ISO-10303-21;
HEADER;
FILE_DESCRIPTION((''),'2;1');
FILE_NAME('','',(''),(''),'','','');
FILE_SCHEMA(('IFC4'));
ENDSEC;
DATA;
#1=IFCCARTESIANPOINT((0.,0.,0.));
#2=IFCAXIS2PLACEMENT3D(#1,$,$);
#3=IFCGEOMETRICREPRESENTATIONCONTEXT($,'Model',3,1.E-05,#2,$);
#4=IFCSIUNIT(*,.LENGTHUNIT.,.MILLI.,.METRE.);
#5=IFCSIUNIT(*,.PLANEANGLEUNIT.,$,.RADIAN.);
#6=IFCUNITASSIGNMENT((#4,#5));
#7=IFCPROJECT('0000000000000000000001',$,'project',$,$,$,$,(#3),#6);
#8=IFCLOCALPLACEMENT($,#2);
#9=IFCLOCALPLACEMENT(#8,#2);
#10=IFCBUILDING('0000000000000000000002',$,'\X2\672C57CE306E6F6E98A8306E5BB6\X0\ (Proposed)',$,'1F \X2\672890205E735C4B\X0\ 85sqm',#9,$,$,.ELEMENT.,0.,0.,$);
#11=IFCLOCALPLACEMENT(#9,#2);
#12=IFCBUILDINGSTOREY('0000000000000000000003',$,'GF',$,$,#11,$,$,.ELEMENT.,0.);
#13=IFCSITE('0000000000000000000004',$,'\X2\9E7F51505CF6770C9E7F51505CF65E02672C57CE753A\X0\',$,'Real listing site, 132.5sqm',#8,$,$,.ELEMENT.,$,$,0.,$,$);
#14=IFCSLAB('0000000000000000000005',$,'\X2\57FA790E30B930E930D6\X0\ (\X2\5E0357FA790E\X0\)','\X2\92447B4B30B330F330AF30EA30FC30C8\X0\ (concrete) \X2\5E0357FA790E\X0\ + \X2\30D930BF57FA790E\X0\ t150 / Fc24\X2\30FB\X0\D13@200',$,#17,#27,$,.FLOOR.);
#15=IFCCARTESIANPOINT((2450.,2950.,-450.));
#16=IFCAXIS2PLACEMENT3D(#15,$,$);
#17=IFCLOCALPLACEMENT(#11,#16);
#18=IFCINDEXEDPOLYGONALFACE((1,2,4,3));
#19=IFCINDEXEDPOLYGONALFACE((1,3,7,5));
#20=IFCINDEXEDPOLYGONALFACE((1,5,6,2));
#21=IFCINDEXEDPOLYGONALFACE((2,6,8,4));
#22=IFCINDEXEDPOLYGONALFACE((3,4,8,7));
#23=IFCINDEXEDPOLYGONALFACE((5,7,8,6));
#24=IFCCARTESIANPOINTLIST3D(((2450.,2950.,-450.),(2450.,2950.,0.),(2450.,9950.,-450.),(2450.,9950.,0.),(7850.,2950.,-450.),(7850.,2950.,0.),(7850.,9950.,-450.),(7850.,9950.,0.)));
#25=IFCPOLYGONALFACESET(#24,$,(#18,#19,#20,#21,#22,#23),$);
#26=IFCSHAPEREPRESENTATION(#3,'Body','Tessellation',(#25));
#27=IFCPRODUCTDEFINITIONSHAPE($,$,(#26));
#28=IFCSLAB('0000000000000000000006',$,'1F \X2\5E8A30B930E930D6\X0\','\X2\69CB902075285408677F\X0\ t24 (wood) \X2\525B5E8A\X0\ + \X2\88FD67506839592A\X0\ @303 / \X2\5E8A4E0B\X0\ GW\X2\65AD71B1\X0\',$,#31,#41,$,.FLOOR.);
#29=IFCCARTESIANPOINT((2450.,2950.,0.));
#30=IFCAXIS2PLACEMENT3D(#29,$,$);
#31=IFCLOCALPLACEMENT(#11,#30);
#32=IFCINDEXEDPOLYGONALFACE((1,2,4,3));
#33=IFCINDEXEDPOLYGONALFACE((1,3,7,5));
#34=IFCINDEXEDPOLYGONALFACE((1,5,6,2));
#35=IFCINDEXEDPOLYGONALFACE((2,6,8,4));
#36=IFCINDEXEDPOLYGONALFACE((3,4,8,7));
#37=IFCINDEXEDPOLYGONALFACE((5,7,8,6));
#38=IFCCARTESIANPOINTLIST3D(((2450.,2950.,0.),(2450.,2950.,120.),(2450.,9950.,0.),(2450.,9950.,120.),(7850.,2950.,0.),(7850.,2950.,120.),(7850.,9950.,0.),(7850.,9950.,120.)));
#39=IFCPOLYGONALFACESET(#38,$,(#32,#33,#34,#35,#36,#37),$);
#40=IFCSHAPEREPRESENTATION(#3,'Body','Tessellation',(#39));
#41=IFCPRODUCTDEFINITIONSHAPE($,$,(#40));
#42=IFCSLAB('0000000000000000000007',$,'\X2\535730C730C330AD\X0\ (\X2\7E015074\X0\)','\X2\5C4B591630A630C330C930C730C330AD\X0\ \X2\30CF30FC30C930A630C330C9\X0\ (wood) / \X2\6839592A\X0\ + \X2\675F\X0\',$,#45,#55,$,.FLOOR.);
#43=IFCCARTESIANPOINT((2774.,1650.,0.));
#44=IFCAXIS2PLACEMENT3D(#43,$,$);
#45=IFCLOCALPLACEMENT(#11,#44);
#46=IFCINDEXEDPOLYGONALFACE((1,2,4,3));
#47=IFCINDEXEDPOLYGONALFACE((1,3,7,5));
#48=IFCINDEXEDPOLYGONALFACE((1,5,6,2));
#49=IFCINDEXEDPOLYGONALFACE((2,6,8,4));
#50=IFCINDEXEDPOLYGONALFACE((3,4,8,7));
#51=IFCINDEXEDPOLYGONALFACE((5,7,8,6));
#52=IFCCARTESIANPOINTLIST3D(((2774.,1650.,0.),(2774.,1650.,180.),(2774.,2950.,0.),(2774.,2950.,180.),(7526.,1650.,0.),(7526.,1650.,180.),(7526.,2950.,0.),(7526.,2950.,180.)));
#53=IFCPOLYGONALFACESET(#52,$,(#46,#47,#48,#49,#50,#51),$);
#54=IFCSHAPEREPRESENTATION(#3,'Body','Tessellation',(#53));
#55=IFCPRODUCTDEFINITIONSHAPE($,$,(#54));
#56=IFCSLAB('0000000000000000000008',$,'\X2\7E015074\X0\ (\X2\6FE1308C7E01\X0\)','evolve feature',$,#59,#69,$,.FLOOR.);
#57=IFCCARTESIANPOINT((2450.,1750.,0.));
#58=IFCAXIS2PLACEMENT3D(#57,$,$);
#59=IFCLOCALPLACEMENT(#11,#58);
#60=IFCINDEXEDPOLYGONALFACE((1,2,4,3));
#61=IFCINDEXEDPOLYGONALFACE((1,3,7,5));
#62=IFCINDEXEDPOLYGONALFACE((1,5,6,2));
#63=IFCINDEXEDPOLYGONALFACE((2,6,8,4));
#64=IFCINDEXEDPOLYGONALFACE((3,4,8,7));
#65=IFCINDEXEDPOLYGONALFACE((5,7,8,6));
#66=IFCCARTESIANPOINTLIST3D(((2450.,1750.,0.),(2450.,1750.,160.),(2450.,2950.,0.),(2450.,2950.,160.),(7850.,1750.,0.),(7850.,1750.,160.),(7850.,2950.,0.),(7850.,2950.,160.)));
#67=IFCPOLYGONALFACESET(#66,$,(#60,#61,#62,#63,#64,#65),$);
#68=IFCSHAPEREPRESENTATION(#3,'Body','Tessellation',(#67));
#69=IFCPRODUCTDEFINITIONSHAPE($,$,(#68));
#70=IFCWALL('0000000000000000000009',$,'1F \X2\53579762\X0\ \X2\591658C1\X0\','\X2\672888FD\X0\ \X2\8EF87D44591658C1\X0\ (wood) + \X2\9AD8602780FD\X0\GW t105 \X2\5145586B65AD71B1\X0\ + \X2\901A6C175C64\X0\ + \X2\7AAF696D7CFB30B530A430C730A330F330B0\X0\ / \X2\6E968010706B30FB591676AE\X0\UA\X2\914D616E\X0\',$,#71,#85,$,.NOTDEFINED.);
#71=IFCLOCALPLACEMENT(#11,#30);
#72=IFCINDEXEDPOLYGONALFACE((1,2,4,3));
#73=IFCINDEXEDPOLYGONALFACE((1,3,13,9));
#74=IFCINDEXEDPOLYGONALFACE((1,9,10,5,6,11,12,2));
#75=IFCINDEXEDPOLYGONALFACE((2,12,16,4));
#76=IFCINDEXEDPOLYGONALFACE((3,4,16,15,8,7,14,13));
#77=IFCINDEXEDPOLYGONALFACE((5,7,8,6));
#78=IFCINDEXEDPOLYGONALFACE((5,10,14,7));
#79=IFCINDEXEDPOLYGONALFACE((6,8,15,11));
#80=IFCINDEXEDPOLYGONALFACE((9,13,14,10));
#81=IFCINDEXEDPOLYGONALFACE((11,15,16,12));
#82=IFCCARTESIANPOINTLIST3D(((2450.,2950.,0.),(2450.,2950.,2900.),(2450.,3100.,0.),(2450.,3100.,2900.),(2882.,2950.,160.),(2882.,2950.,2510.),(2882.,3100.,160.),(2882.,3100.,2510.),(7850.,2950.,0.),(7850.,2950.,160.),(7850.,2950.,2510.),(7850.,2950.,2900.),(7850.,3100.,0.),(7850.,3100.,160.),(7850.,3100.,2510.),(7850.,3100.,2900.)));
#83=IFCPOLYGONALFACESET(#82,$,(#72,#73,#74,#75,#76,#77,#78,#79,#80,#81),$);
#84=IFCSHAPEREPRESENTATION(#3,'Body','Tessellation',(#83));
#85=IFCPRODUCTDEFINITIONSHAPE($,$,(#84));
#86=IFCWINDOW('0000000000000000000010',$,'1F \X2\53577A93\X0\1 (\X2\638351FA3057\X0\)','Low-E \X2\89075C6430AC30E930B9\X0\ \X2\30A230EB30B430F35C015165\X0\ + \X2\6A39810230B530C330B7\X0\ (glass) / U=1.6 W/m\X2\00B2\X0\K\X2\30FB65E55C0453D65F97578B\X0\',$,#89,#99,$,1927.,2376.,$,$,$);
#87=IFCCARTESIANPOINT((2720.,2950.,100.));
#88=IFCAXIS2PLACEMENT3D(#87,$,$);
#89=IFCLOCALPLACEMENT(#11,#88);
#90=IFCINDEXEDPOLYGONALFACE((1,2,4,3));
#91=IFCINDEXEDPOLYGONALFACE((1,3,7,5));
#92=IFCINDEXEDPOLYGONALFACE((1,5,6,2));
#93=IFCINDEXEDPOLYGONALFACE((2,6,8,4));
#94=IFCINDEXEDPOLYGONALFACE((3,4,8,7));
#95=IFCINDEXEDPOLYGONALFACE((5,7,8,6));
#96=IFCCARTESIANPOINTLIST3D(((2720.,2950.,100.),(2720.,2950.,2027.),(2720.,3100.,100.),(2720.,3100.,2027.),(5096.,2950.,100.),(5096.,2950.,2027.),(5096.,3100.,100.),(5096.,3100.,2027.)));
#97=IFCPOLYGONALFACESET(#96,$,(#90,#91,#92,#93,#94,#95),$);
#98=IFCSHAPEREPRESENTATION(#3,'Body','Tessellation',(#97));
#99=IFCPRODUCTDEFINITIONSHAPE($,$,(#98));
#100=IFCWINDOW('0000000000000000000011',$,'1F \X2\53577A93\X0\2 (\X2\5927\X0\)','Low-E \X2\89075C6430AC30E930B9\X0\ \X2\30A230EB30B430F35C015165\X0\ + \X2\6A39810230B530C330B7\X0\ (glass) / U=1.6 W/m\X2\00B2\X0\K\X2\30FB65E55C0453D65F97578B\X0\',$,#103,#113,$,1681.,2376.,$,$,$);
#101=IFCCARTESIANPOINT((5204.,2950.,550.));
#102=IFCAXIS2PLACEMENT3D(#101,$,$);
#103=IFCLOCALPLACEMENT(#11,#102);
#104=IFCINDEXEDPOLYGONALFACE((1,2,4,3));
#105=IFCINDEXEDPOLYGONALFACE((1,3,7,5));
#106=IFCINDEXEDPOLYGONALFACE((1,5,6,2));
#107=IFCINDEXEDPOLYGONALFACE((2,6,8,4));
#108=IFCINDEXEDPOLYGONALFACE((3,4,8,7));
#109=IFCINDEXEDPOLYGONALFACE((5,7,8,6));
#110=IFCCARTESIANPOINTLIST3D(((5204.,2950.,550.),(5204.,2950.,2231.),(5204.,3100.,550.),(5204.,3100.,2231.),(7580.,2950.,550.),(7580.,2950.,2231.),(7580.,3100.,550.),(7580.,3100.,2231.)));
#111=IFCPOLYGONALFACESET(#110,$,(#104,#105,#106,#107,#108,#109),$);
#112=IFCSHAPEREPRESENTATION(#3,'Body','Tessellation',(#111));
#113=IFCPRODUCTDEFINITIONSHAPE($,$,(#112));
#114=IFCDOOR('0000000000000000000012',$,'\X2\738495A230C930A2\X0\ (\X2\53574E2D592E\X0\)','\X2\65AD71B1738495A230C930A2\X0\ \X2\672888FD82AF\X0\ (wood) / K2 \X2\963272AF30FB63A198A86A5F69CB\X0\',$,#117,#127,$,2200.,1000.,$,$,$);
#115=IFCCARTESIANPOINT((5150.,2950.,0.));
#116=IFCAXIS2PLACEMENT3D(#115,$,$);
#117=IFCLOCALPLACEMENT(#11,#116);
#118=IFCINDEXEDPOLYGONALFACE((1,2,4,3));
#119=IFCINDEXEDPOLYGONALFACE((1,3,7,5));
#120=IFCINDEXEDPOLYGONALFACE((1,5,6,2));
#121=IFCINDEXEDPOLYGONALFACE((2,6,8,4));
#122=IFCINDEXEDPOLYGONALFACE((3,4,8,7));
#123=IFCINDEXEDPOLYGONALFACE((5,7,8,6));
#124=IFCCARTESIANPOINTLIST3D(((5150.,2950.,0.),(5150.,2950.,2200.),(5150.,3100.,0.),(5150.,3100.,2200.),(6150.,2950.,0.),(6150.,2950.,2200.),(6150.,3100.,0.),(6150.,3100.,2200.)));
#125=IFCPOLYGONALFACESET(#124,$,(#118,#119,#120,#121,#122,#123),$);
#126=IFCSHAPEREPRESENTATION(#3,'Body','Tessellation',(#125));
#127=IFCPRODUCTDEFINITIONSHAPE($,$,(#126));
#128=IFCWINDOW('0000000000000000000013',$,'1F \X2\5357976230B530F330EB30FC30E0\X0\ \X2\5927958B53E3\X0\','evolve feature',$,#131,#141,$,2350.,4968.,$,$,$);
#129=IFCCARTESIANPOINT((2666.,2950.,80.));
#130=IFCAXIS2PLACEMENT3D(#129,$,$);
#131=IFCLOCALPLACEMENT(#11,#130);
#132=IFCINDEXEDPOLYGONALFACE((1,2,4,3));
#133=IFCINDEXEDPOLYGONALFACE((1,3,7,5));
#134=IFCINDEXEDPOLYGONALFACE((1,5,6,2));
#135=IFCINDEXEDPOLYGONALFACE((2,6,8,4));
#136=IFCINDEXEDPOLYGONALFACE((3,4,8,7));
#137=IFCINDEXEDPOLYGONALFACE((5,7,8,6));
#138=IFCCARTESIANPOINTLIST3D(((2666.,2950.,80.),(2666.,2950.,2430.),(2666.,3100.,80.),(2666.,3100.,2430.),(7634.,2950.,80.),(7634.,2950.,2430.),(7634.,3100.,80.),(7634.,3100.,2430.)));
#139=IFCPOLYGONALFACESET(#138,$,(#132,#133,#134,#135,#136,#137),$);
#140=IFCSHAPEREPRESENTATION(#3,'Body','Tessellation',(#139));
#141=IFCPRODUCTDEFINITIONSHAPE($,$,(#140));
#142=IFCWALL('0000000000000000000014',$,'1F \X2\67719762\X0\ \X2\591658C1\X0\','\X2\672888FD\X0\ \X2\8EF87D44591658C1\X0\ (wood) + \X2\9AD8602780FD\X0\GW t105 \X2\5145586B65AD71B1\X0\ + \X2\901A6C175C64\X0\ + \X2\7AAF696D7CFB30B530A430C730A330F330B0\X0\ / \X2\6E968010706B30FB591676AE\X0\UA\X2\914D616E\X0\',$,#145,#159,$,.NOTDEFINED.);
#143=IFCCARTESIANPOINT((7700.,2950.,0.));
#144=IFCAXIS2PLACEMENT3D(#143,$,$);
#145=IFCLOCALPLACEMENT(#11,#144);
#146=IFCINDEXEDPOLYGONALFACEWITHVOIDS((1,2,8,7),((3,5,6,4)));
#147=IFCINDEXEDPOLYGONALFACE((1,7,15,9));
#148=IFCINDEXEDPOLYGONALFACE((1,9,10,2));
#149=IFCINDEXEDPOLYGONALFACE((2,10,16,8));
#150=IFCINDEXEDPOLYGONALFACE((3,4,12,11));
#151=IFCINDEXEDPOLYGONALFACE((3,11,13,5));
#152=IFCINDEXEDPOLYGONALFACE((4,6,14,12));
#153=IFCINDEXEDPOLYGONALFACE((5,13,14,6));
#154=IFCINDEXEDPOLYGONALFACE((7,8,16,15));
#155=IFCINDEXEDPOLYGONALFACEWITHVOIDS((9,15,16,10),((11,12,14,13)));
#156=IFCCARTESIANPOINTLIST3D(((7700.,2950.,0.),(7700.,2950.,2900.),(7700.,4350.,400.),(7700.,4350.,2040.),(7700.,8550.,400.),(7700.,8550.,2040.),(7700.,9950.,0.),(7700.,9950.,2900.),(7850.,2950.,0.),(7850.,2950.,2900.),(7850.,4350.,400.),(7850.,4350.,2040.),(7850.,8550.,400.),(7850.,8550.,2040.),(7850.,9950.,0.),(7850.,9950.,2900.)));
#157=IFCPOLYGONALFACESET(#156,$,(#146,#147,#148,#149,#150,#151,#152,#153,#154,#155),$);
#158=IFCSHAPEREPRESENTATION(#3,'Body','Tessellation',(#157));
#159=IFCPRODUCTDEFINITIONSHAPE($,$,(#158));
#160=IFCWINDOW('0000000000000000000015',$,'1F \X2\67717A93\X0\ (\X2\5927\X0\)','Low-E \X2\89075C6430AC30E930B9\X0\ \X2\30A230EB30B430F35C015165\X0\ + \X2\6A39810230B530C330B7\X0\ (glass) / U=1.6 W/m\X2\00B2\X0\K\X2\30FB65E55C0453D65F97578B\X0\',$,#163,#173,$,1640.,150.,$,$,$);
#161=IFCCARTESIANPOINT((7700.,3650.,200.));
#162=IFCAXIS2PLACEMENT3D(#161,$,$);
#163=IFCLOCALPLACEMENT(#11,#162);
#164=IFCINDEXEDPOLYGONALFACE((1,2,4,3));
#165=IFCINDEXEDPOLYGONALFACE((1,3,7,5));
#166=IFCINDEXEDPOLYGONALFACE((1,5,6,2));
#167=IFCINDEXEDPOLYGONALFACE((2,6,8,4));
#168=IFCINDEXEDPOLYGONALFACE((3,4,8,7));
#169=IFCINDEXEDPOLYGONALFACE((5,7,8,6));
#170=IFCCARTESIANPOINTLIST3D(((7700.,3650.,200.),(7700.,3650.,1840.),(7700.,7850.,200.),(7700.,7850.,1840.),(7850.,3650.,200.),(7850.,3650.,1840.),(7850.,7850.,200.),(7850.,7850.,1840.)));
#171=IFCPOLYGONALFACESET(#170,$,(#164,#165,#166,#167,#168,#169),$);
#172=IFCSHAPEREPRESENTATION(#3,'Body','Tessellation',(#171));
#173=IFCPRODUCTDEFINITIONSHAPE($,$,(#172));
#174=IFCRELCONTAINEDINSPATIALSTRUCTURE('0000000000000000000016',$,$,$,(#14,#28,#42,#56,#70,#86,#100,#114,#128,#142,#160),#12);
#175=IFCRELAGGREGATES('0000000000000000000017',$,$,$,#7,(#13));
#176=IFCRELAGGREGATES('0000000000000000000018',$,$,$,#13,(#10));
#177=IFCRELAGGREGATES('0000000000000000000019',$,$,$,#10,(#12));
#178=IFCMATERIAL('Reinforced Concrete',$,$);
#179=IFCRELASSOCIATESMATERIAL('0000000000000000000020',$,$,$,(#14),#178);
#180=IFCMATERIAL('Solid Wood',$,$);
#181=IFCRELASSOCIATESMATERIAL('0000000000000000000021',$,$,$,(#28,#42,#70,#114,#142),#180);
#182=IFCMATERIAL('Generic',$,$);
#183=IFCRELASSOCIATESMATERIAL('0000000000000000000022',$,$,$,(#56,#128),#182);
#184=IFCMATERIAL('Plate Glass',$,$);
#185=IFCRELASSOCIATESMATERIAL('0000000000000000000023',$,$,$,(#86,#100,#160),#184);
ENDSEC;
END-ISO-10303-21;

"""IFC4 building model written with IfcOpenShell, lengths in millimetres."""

from ifc_helpers import new_model, si_unit, frame, frame_2d, origin, place, context, project, spatial, rectangle, extrude, material, element, fill, save


model = new_model("IFC4")

# Units and contexts
model_context = context("Model", 3, precision=1e-05, world=origin())
ifc_project = project(units=[si_unit("LENGTHUNIT", "METRE", prefix="MILLI"), si_unit("PLANEANGLEUNIT", "RADIAN")], contexts=[model_context])

# Site, building, storey
site_placement = place(None, origin())
site = spatial("IfcSite", under=ifc_project, at=site_placement, Name="鹿児島県鹿児島市本城町", ObjectType="Real listing site, 132.5sqm", CompositionType="ELEMENT", RefElevation=0.0)
building_placement = place(site_placement, origin())
building = spatial("IfcBuilding", under=site, at=building_placement, Name="本城の潮風の家 (Proposed)", ObjectType="1F 木造平屋 85sqm", CompositionType="ELEMENT", ElevationOfRefHeight=0.0, ElevationOfTerrain=0.0)
storey_placement = place(building_placement, origin())
storey = spatial("IfcBuildingStorey", under=building, at=storey_placement, Name="GF", CompositionType="ELEMENT", Elevation=0.0)

# Slabs
ifc_material_1 = material(Name="Reinforced Concrete")
slab_1_placement = place(storey_placement, frame((2450.0, 2950.0, -450.0)))
element("IfcSlab", 1, at=slab_1_placement, inside=storey, material=ifc_material_1, Name="基礎スラブ (布基礎)", Description="鉄筋コンクリート (concrete) 布基礎 + ベタ基礎 t150 / Fc24・D13@200", PredefinedType="FLOOR", context=model_context, shape_type="SweptSolid", body=[
    extrude(rectangle(XDim=5400.0, YDim=7000.0, at=frame_2d((2700.0, 3500.0))), frame((2450.0, 2950.0, -450.0)), (0.0, 0.0, 1.0), 450.0),
])
ifc_material_2 = material(Name="Solid Wood")
slab_2_placement = place(storey_placement, frame((2450.0, 2950.0, 0.0)))
element("IfcSlab", 2, at=slab_2_placement, inside=storey, material=ifc_material_2, Name="1F 床スラブ", Description="構造用合板 t24 (wood) 剛床 + 製材根太 @303 / 床下 GW断熱", PredefinedType="FLOOR", context=model_context, shape_type="SweptSolid", body=[
    extrude(rectangle(XDim=5400.0, YDim=7000.0, at=frame_2d((2700.0, 3500.0))), frame((2450.0, 2950.0, 0.0)), (0.0, 0.0, 1.0), 120.0),
])
slab_3_placement = place(storey_placement, frame((2774.0, 1650.0, 0.0)))
element("IfcSlab", 3, at=slab_3_placement, inside=storey, material=ifc_material_2, Name="南デッキ (縁側)", Description="屋外ウッドデッキ ハードウッド (wood) / 根太 + 束", PredefinedType="FLOOR", context=model_context, shape_type="SweptSolid", body=[
    extrude(rectangle(XDim=4752.0, YDim=1300.0, at=frame_2d((2376.0, 650.0))), frame((2774.0, 1650.0, 0.0)), (0.0, 0.0, 1.0), 180.0),
])
ifc_material_3 = material(Name="Generic")
slab_4_placement = place(storey_placement, frame((2450.0, 1750.0, 0.0)))
element("IfcSlab", 4, at=slab_4_placement, inside=storey, material=ifc_material_3, Name="縁側 (濡れ縁)", Description="evolve feature", PredefinedType="FLOOR", context=model_context, shape_type="SweptSolid", body=[
    extrude(rectangle(XDim=5400.0, YDim=1200.0, at=frame_2d((2700.0, 600.0))), frame((2450.0, 1750.0, 0.0)), (0.0, 0.0, 1.0), 160.0),
])

# Wall, openings, windows, door
wall_1_placement = place(storey_placement, frame((2450.0, 2950.0, 0.0)))
wall_1 = element("IfcWall", 5, at=wall_1_placement, inside=storey, material=ifc_material_2, Name="1F 南面 外壁", Description="木製 軸組外壁 (wood) + 高性能GW t105 充填断熱 + 通気層 + 窯業系サイディング / 準耐火・外皮UA配慮", PredefinedType="NOTDEFINED", context=model_context, shape_type="SweptSolid", body=[
    extrude(rectangle(XDim=5400.0, YDim=150.0, at=frame_2d((2700.0, 75.0))), frame((2450.0, 2950.0, 0.0)), (0.0, 0.0, 1.0), 2900.0),
])
opening_1_placement = place(storey_placement, frame((2720.0, 2950.0, 100.0)))
opening_1 = element("IfcOpeningElement", 6, at=opening_1_placement, cuts=wall_1, PredefinedType="NOTDEFINED", context=model_context, shape_type="SweptSolid", body=[
    extrude(rectangle(XDim=2376.0, YDim=150.0, at=frame_2d((1188.0, 75.0))), frame((2720.0, 2950.0, 100.0)), (0.0, 0.0, 1.0), 1927.0),
])
opening_2_placement = place(storey_placement, frame((5204.0, 2950.0, 550.0)))
opening_2 = element("IfcOpeningElement", 7, at=opening_2_placement, cuts=wall_1, PredefinedType="NOTDEFINED", context=model_context, shape_type="SweptSolid", body=[
    extrude(rectangle(XDim=2376.0, YDim=150.0, at=frame_2d((1188.0, 75.0))), frame((5204.0, 2950.0, 550.0)), (0.0, 0.0, 1.0), 1681.0),
])
opening_3_placement = place(storey_placement, frame((5150.0, 2950.0, 0.0)))
opening_3 = element("IfcOpeningElement", 8, at=opening_3_placement, cuts=wall_1, PredefinedType="NOTDEFINED", context=model_context, shape_type="SweptSolid", body=[
    extrude(rectangle(XDim=1000.0, YDim=150.0, at=frame_2d((500.0, 75.0))), frame((5150.0, 2950.0, 0.0)), (0.0, 0.0, 1.0), 2200.0),
])
opening_4_placement = place(storey_placement, frame((2666.0, 2950.0, 80.0)))
opening_4 = element("IfcOpeningElement", 9, at=opening_4_placement, cuts=wall_1, PredefinedType="NOTDEFINED", context=model_context, shape_type="SweptSolid", body=[
    extrude(rectangle(XDim=4968.0, YDim=150.0, at=frame_2d((2484.0, 75.0))), frame((2666.0, 2950.0, 80.0)), (0.0, 0.0, 1.0), 2350.0),
])
ifc_material_4 = material(Name="Plate Glass")
window_1_placement = place(storey_placement, frame((2720.0, 2950.0, 100.0)))
window_1 = element("IfcWindow", 10, at=window_1_placement, inside=storey, material=ifc_material_4, Name="1F 南窓1 (掃出し)", Description="Low-E 複層ガラス アルゴン封入 + 樹脂サッシ (glass) / U=1.6 W/m²K・日射取得型", OverallHeight=1927.0, OverallWidth=2376.0, context=model_context, shape_type="SweptSolid", body=[
    extrude(rectangle(XDim=2376.0, YDim=150.0, at=frame_2d((1188.0, 75.0))), frame((2720.0, 2950.0, 100.0)), (0.0, 0.0, 1.0), 1927.0),
])
fill(opening_1, window_1)
window_2_placement = place(storey_placement, frame((5204.0, 2950.0, 550.0)))
window_2 = element("IfcWindow", 11, at=window_2_placement, inside=storey, material=ifc_material_4, Name="1F 南窓2 (大)", Description="Low-E 複層ガラス アルゴン封入 + 樹脂サッシ (glass) / U=1.6 W/m²K・日射取得型", OverallHeight=1681.0, OverallWidth=2376.0, context=model_context, shape_type="SweptSolid", body=[
    extrude(rectangle(XDim=2376.0, YDim=150.0, at=frame_2d((1188.0, 75.0))), frame((5204.0, 2950.0, 550.0)), (0.0, 0.0, 1.0), 1681.0),
])
fill(opening_2, window_2)
door_placement = place(storey_placement, frame((5150.0, 2950.0, 0.0)))
door = element("IfcDoor", 12, at=door_placement, inside=storey, material=ifc_material_2, Name="玄関ドア (南中央)", Description="断熱玄関ドア 木製芯 (wood) / K2 防犯・採風機構", OverallHeight=2200.0, OverallWidth=1000.0, context=model_context, shape_type="SweptSolid", body=[
    extrude(rectangle(XDim=1000.0, YDim=150.0, at=frame_2d((500.0, 75.0))), frame((5150.0, 2950.0, 0.0)), (0.0, 0.0, 1.0), 2200.0),
])
fill(opening_3, door)
window_3_placement = place(storey_placement, frame((2666.0, 2950.0, 80.0)))
window_3 = element("IfcWindow", 13, at=window_3_placement, inside=storey, material=ifc_material_3, Name="1F 南面サンルーム 大開口", Description="evolve feature", OverallHeight=2350.0, OverallWidth=4968.0, context=model_context, shape_type="SweptSolid", body=[
    extrude(rectangle(XDim=4968.0, YDim=150.0, at=frame_2d((2484.0, 75.0))), frame((2666.0, 2950.0, 80.0)), (0.0, 0.0, 1.0), 2350.0),
])
fill(opening_4, window_3)

# Wall, opening, window
wall_2_placement = place(storey_placement, frame((7700.0, 2950.0, 0.0)))
wall_2 = element("IfcWall", 14, at=wall_2_placement, inside=storey, material=ifc_material_2, Name="1F 東面 外壁", Description="木製 軸組外壁 (wood) + 高性能GW t105 充填断熱 + 通気層 + 窯業系サイディング / 準耐火・外皮UA配慮", PredefinedType="NOTDEFINED", context=model_context, shape_type="SweptSolid", body=[
    extrude(rectangle(XDim=150.0, YDim=7000.0, at=frame_2d((75.0, 3500.0))), frame((7700.0, 2950.0, 0.0)), (0.0, 0.0, 1.0), 2900.0),
])
opening_5_placement = place(storey_placement, frame((7700.0, 3650.0, 200.0)))
opening_5 = element("IfcOpeningElement", 15, at=opening_5_placement, cuts=wall_2, PredefinedType="NOTDEFINED", context=model_context, shape_type="SweptSolid", body=[
    extrude(rectangle(XDim=150.0, YDim=4200.0, at=frame_2d((75.0, 2100.0))), frame((7700.0, 3650.0, 200.0)), (0.0, 0.0, 1.0), 1640.0),
])
window_4_placement = place(storey_placement, frame((7700.0, 3650.0, 200.0)))
window_4 = element("IfcWindow", 16, at=window_4_placement, inside=storey, material=ifc_material_4, Name="1F 東窓 (大)", Description="Low-E 複層ガラス アルゴン封入 + 樹脂サッシ (glass) / U=1.6 W/m²K・日射取得型", OverallHeight=1640.0, OverallWidth=150.0, context=model_context, shape_type="SweptSolid", body=[
    extrude(rectangle(XDim=150.0, YDim=4200.0, at=frame_2d((75.0, 2100.0))), frame((7700.0, 3650.0, 200.0)), (0.0, 0.0, 1.0), 1640.0),
])
fill(opening_5, window_4)

save(model, "model.ifc")
